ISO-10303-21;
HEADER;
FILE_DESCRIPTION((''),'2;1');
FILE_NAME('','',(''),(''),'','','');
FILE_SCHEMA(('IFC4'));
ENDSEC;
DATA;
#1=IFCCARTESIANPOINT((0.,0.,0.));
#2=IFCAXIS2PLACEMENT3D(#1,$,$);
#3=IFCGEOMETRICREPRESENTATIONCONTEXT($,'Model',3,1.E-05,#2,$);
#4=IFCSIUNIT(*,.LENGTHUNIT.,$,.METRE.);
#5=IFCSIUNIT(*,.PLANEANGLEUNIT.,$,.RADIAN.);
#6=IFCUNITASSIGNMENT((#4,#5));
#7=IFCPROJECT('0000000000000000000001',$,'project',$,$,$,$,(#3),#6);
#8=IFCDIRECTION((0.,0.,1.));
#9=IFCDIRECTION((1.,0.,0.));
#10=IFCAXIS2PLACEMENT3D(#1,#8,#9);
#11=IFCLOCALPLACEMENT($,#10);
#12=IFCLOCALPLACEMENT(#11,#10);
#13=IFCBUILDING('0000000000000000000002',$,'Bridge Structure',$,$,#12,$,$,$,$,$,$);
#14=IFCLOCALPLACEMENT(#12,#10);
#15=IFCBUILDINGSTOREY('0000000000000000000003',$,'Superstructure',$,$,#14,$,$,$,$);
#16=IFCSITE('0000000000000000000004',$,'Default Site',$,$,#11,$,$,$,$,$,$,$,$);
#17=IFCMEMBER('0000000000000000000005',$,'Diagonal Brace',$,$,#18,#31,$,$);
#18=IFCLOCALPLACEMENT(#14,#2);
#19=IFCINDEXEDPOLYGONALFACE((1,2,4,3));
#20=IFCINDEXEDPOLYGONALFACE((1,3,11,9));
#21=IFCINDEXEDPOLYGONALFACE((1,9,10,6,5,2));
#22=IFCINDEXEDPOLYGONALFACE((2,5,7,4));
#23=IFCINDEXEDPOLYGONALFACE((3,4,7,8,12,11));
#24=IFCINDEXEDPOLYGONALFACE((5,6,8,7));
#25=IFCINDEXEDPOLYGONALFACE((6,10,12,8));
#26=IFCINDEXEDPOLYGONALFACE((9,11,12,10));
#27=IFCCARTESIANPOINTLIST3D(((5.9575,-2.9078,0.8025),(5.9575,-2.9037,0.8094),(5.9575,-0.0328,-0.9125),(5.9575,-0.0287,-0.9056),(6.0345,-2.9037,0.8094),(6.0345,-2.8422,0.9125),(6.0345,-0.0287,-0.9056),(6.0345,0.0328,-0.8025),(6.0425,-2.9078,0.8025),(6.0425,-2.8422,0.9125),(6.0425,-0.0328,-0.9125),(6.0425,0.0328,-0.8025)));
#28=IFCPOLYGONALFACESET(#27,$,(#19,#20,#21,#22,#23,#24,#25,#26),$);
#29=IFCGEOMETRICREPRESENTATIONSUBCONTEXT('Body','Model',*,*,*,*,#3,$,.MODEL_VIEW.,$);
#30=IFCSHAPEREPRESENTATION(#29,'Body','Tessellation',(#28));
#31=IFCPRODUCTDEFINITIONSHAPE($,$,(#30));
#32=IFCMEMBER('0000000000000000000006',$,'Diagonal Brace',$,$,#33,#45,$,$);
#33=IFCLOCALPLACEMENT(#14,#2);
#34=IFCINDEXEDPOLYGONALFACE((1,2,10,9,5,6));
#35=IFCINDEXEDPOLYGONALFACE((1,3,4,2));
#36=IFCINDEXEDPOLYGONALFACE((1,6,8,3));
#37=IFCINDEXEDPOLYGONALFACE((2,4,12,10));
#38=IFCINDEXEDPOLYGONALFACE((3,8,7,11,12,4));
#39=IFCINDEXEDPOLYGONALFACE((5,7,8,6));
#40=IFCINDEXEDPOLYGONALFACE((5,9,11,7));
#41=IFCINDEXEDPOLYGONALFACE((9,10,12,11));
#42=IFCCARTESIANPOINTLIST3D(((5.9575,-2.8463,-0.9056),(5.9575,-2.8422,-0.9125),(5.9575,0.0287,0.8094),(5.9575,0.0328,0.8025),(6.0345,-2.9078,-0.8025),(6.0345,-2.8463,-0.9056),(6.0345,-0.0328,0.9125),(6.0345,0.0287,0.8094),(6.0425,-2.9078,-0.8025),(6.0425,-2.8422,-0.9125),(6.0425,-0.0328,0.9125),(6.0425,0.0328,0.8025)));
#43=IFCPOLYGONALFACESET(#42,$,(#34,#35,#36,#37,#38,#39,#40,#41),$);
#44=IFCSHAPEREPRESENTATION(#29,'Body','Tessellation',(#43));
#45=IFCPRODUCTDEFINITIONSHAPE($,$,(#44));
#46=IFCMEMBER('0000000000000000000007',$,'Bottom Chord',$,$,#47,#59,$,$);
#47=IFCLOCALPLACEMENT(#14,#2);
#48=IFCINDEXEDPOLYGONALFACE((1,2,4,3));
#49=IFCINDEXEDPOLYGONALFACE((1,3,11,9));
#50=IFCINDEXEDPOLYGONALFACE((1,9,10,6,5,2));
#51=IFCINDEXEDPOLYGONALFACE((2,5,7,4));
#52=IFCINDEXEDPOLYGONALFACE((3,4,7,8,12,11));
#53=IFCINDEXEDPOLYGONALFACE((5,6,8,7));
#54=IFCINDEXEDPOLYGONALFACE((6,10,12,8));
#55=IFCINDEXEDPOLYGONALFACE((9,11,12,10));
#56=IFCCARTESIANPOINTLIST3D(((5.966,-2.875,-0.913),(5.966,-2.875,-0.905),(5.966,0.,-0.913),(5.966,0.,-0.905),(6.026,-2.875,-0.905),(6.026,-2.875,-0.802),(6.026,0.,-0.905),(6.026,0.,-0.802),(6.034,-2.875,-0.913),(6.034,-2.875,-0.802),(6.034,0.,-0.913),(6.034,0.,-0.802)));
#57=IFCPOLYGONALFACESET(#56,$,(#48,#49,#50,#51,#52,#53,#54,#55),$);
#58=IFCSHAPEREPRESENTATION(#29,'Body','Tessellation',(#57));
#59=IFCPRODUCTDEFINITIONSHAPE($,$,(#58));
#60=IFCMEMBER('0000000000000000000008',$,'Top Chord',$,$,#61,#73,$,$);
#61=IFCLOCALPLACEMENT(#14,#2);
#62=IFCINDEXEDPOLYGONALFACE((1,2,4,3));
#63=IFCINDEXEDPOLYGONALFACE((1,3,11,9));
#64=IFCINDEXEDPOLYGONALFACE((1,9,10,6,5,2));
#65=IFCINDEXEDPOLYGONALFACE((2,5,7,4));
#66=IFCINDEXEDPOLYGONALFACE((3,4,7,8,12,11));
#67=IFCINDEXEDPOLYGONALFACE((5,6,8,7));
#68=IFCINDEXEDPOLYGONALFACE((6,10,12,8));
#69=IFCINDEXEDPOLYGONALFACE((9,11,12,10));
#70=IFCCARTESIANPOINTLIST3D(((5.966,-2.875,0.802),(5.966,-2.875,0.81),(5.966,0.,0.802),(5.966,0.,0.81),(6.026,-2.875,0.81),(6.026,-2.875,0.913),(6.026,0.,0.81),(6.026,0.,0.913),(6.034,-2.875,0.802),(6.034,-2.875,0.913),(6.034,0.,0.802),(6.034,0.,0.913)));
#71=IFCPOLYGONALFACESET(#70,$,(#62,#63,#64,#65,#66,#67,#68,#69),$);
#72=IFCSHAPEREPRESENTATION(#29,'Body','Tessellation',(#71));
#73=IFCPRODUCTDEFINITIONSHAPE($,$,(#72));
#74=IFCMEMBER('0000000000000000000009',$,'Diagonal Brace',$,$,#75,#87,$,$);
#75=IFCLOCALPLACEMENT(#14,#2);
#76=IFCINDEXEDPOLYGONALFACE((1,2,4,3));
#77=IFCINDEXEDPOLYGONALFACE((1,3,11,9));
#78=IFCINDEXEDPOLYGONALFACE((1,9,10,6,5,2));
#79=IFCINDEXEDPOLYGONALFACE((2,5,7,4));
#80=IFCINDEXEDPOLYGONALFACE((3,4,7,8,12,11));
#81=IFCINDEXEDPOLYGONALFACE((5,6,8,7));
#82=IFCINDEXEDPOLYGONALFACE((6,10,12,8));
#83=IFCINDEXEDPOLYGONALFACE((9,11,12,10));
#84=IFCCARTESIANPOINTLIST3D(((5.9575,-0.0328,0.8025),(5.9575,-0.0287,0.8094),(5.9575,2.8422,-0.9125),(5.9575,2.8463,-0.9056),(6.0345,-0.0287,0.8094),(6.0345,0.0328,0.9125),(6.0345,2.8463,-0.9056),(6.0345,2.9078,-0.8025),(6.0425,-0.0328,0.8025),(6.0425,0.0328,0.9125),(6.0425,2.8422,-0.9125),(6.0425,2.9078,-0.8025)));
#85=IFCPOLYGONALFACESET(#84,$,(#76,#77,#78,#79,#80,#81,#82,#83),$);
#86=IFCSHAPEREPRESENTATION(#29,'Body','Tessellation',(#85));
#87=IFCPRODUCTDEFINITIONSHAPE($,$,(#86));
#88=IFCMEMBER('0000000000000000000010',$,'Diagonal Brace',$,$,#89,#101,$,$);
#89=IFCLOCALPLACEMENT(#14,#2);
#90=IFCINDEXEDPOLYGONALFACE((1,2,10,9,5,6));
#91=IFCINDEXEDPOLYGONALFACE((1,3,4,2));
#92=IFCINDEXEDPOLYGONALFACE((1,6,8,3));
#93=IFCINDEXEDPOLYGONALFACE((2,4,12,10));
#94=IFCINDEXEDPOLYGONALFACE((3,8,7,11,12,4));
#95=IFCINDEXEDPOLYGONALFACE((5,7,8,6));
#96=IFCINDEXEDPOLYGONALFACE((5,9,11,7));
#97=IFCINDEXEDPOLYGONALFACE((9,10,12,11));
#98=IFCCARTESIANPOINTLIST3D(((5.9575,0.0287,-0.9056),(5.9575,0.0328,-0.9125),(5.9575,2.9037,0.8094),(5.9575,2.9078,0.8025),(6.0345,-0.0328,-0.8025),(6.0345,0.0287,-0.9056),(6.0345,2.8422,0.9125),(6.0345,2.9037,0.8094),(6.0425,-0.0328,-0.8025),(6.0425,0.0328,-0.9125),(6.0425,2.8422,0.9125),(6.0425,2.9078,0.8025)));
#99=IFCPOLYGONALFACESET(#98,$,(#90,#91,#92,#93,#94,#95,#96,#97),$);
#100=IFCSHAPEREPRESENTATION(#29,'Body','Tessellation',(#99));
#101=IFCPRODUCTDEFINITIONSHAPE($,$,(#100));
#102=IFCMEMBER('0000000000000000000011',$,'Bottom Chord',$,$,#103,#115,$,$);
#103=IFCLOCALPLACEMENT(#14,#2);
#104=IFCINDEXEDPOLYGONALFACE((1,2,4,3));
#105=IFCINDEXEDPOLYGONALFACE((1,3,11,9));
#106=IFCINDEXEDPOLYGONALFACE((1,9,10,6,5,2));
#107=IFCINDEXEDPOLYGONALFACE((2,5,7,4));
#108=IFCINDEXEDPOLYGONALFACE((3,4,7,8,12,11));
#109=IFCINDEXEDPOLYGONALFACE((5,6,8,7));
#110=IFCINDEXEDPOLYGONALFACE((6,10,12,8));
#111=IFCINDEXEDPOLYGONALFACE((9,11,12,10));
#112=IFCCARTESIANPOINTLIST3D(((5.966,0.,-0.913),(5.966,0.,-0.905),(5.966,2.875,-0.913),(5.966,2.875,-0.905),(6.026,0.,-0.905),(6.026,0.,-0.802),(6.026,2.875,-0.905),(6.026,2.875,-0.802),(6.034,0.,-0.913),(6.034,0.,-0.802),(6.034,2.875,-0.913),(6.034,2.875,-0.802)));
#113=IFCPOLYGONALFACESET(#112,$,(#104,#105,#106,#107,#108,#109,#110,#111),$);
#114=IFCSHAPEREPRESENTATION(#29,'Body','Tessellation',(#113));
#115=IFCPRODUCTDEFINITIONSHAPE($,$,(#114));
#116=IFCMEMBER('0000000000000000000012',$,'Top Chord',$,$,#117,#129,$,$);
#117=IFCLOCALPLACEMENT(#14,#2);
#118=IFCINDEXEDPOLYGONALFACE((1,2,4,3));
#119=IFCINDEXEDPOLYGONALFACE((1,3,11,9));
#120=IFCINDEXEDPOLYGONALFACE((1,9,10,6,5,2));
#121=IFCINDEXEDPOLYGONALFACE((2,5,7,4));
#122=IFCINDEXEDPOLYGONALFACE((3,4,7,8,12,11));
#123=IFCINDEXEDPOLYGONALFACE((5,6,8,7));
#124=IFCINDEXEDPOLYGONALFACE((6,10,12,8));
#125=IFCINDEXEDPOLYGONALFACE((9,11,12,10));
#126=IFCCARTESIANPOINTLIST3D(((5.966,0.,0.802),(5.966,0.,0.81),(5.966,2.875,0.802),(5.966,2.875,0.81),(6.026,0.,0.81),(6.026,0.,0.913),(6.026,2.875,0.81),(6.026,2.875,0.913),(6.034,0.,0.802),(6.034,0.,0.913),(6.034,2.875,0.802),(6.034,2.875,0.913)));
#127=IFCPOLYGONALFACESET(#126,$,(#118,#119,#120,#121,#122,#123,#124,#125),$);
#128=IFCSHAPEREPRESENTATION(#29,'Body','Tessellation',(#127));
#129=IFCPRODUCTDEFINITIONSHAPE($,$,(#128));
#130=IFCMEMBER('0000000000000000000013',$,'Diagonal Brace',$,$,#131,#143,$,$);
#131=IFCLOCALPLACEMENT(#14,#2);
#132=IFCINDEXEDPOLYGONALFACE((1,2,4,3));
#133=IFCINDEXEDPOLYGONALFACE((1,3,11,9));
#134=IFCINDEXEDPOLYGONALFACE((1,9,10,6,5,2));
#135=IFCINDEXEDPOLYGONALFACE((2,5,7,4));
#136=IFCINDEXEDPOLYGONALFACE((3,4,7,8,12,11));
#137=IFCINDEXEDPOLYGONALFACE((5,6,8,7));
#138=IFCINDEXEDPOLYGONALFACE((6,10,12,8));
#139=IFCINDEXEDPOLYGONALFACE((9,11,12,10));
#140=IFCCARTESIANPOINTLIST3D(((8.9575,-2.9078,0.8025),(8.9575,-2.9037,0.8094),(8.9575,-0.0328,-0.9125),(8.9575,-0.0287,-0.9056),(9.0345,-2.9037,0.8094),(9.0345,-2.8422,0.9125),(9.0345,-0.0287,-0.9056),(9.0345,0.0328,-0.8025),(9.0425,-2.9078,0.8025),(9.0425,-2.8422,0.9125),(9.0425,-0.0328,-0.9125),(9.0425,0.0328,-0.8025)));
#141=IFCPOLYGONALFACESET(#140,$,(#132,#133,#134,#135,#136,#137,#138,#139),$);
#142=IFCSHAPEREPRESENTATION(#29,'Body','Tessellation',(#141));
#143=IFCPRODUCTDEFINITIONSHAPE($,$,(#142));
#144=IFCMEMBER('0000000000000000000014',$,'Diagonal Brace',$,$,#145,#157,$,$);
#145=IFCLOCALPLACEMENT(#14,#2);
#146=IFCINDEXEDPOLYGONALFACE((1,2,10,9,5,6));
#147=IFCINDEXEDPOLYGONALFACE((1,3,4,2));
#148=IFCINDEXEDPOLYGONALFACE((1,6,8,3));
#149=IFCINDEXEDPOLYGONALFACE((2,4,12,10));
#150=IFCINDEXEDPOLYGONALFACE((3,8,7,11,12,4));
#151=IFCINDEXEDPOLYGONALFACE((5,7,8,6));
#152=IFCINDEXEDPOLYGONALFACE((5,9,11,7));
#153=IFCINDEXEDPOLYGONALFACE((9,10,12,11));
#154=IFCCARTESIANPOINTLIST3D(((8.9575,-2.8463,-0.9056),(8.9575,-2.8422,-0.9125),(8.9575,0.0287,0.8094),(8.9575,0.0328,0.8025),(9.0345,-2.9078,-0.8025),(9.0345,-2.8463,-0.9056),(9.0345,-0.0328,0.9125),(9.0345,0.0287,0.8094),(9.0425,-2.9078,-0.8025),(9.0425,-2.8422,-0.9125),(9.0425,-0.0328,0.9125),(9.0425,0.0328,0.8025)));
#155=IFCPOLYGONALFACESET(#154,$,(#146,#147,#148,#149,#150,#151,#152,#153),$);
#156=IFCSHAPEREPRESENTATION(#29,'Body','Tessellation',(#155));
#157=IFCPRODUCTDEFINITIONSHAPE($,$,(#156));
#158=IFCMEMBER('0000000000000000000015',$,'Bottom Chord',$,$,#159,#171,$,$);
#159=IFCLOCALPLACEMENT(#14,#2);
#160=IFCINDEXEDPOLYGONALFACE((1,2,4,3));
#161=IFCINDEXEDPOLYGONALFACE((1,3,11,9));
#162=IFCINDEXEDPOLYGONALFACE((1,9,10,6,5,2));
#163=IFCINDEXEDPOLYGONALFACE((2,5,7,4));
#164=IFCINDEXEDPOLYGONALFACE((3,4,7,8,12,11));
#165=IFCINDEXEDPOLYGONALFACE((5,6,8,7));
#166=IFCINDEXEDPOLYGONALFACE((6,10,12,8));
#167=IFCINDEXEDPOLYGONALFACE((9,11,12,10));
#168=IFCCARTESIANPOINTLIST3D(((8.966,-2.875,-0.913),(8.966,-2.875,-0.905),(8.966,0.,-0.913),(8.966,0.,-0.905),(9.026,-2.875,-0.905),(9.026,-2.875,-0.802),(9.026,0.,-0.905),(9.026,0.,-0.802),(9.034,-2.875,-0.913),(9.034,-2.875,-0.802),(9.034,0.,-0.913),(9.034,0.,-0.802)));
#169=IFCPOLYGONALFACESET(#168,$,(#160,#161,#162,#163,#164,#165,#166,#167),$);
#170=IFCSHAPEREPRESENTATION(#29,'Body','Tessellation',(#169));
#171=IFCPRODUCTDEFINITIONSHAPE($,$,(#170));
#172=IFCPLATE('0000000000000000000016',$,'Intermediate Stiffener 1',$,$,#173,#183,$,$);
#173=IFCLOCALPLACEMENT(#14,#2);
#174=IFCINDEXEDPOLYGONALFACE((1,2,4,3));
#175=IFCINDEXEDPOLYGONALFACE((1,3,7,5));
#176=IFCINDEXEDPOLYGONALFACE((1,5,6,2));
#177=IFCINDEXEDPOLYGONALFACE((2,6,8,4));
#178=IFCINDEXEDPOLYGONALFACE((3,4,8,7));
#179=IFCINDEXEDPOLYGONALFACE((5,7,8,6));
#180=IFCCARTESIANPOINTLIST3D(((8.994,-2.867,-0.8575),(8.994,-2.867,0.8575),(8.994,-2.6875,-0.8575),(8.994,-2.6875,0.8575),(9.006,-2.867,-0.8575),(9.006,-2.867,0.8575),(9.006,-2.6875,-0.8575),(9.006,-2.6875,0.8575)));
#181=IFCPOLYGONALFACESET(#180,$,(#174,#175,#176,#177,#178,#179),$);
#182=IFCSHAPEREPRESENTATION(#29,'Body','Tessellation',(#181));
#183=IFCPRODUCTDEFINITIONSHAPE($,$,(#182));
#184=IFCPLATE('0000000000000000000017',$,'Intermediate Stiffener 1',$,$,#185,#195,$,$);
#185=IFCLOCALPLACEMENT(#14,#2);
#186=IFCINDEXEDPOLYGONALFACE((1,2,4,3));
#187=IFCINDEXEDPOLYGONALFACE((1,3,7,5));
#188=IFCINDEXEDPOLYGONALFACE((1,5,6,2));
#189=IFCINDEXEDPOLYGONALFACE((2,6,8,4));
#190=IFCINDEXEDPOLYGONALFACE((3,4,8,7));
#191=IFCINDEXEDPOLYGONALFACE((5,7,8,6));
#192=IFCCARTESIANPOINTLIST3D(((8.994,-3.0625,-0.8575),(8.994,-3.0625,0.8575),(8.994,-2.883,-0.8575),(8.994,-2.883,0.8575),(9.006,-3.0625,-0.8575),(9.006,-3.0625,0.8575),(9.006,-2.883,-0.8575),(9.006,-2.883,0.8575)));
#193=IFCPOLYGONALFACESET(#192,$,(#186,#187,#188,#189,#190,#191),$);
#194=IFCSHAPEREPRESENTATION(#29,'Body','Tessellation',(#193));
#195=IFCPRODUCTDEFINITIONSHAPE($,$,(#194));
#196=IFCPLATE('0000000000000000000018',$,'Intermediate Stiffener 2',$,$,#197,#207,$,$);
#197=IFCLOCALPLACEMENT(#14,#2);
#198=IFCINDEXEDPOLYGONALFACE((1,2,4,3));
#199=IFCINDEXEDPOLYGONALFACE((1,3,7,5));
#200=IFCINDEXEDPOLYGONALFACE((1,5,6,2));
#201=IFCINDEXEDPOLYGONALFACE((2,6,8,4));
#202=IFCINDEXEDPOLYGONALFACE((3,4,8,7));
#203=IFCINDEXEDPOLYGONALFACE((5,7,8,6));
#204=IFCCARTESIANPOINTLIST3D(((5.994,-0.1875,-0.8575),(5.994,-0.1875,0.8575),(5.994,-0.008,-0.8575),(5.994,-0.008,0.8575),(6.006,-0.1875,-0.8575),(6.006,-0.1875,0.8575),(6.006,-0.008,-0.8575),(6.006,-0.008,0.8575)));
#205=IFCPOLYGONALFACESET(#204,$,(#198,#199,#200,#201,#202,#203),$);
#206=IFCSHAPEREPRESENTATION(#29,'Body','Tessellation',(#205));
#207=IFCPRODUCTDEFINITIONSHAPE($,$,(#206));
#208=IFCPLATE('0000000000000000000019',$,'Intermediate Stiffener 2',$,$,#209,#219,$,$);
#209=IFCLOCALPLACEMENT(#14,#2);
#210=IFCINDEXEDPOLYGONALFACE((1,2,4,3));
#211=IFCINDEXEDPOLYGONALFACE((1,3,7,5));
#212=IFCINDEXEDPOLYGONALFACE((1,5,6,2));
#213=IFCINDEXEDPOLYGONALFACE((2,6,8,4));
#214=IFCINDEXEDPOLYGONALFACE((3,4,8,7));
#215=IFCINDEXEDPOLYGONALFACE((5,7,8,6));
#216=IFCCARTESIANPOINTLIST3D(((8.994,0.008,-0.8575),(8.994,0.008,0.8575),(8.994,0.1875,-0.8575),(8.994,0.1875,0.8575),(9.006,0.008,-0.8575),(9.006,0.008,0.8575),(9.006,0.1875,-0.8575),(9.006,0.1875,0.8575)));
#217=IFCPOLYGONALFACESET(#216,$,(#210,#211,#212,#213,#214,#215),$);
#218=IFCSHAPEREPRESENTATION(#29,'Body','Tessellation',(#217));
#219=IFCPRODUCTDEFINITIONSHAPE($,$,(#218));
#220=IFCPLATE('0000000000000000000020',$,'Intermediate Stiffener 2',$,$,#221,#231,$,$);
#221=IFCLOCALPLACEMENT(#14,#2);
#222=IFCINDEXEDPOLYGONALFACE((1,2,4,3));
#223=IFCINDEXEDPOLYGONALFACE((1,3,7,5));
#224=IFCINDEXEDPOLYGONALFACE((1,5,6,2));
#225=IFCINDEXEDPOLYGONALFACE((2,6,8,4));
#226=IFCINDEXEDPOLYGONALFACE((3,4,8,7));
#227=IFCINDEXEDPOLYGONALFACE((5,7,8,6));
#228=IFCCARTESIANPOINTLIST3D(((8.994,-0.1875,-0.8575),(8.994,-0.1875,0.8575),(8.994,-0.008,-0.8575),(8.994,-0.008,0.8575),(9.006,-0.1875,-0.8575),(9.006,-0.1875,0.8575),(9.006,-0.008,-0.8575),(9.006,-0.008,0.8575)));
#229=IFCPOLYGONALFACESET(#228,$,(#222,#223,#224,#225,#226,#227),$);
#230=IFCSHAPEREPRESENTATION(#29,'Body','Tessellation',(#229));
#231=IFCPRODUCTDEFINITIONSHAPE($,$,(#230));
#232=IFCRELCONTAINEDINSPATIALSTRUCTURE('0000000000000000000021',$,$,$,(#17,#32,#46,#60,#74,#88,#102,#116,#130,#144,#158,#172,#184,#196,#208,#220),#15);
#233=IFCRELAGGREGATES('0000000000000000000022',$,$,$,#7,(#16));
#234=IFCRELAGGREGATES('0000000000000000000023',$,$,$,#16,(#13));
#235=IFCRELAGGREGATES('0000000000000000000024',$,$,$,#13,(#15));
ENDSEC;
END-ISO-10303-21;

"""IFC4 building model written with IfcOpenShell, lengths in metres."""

from ifc_helpers import new_model, si_unit, frame, origin, origin_with_axes, origin_2d_with_axis, place, context, subcontext, project, spatial, rectangle, l_section, extrude, element, save


model = new_model("IFC4")

# Units and contexts
model_context = context("Model", 3, precision=1e-05, world=origin())
body_context = subcontext(model_context, "Body", "Model", "MODEL_VIEW")
ifc_project = project(units=[si_unit("LENGTHUNIT", "METRE"), si_unit("PLANEANGLEUNIT", "RADIAN")], contexts=[model_context])

# Site, building, storey
site_placement = place(None, origin_with_axes())
site = spatial("IfcSite", under=ifc_project, at=site_placement, Name="Default Site")
building_placement = place(site_placement, origin_with_axes())
building = spatial("IfcBuilding", under=site, at=building_placement, Name="Bridge Structure")
storey_placement = place(building_placement, origin_with_axes())
storey = spatial("IfcBuildingStorey", under=building, at=storey_placement, Name="Superstructure")

# Members
for number, where, z_axis, x_axis, name in (
    (1, (6.0, -2.875, 0.8575), (0.0, 0.858808, -0.512298), (-1.0, 0.0, 0.0), "Diagonal Brace"),
    (2, (6.0, -2.875, -0.8575), (0.0, 0.858808, 0.512298), (-1.0, 0.0, 0.0), "Diagonal Brace"),
):
    element("IfcMember", number, at=place(storey_placement, frame(where, z_axis=z_axis, x_axis=x_axis)), inside=storey, Name=name, context=body_context, shape_type="SweptSolid", body=[
        extrude(l_section(Depth=0.128, Width=0.085, Thickness=0.008, at=origin_2d_with_axis()), origin_with_axes(), (0.0, 0.0, 1.0), 3.3477),
    ])
for number, where, z_axis, x_axis, name in (
    (3, (6.0, -2.875, -0.8575), (0.0, 1.0, 0.0), (-1.0, 0.0, 0.0), "Bottom Chord"),
    (4, (6.0, -2.875, 0.8575), (0.0, 1.0, 0.0), (-1.0, 0.0, 0.0), "Top Chord"),
):
    element("IfcMember", number, at=place(storey_placement, frame(where, z_axis=z_axis, x_axis=x_axis)), inside=storey, Name=name, context=body_context, shape_type="SweptSolid", body=[
        extrude(l_section(Depth=0.111, Width=0.068, Thickness=0.008, at=origin_2d_with_axis()), origin_with_axes(), (0.0, 0.0, 1.0), 2.875),
    ])
for number, where, z_axis, x_axis, name in (
    (5, (6.0, 0.0, 0.8575), (0.0, 0.858808, -0.512298), (-1.0, 0.0, 0.0), "Diagonal Brace"),
    (6, (6.0, 0.0, -0.8575), (0.0, 0.858808, 0.512298), (-1.0, 0.0, 0.0), "Diagonal Brace"),
):
    element("IfcMember", number, at=place(storey_placement, frame(where, z_axis=z_axis, x_axis=x_axis)), inside=storey, Name=name, context=body_context, shape_type="SweptSolid", body=[
        extrude(l_section(Depth=0.128, Width=0.085, Thickness=0.008, at=origin_2d_with_axis()), origin_with_axes(), (0.0, 0.0, 1.0), 3.3477),
    ])
for number, where, z_axis, x_axis, name in (
    (7, (6.0, 0.0, -0.8575), (0.0, 1.0, 0.0), (-1.0, 0.0, 0.0), "Bottom Chord"),
    (8, (6.0, 0.0, 0.8575), (0.0, 1.0, 0.0), (-1.0, 0.0, 0.0), "Top Chord"),
):
    element("IfcMember", number, at=place(storey_placement, frame(where, z_axis=z_axis, x_axis=x_axis)), inside=storey, Name=name, context=body_context, shape_type="SweptSolid", body=[
        extrude(l_section(Depth=0.111, Width=0.068, Thickness=0.008, at=origin_2d_with_axis()), origin_with_axes(), (0.0, 0.0, 1.0), 2.875),
    ])
for number, where, z_axis, x_axis, name in (
    (9, (9.0, -2.875, 0.8575), (0.0, 0.858808, -0.512298), (-1.0, 0.0, 0.0), "Diagonal Brace"),
    (10, (9.0, -2.875, -0.8575), (0.0, 0.858808, 0.512298), (-1.0, 0.0, 0.0), "Diagonal Brace"),
):
    element("IfcMember", number, at=place(storey_placement, frame(where, z_axis=z_axis, x_axis=x_axis)), inside=storey, Name=name, context=body_context, shape_type="SweptSolid", body=[
        extrude(l_section(Depth=0.128, Width=0.085, Thickness=0.008, at=origin_2d_with_axis()), origin_with_axes(), (0.0, 0.0, 1.0), 3.3477),
    ])
member_placement = place(storey_placement, frame((9.0, -2.875, -0.8575), z_axis=(0.0, 1.0, 0.0), x_axis=(-1.0, 0.0, 0.0)))
element("IfcMember", 11, at=member_placement, inside=storey, Name="Bottom Chord", context=body_context, shape_type="SweptSolid", body=[
    extrude(l_section(Depth=0.111, Width=0.068, Thickness=0.008, at=origin_2d_with_axis()), origin_with_axes(), (0.0, 0.0, 1.0), 2.875),
])

# Plates
for number, where, z_axis, x_axis, name in (
    (12, (9.0, -2.7772, -0.8575), (0.0, 0.0, 1.0), (1.0, 0.0, 0.0), "Intermediate Stiffener 1"),
    (13, (9.0, -2.9728, -0.8575), (0.0, 0.0, 1.0), (1.0, 0.0, 0.0), "Intermediate Stiffener 1"),
    (14, (6.0, -0.0978, -0.8575), (0.0, 0.0, 1.0), (1.0, 0.0, 0.0), "Intermediate Stiffener 2"),
    (15, (9.0, 0.0978, -0.8575), (0.0, 0.0, 1.0), (1.0, 0.0, 0.0), "Intermediate Stiffener 2"),
    (16, (9.0, -0.0978, -0.8575), (0.0, 0.0, 1.0), (1.0, 0.0, 0.0), "Intermediate Stiffener 2"),
):
    element("IfcPlate", number, at=place(storey_placement, frame(where, z_axis=z_axis, x_axis=x_axis)), inside=storey, Name=name, context=body_context, shape_type="SweptSolid", body=[
        extrude(rectangle(XDim=0.012, YDim=0.1795, at=origin_2d_with_axis()), origin_with_axes(), (0.0, 0.0, 1.0), 1.715),
    ])

save(model, "model.ifc")
